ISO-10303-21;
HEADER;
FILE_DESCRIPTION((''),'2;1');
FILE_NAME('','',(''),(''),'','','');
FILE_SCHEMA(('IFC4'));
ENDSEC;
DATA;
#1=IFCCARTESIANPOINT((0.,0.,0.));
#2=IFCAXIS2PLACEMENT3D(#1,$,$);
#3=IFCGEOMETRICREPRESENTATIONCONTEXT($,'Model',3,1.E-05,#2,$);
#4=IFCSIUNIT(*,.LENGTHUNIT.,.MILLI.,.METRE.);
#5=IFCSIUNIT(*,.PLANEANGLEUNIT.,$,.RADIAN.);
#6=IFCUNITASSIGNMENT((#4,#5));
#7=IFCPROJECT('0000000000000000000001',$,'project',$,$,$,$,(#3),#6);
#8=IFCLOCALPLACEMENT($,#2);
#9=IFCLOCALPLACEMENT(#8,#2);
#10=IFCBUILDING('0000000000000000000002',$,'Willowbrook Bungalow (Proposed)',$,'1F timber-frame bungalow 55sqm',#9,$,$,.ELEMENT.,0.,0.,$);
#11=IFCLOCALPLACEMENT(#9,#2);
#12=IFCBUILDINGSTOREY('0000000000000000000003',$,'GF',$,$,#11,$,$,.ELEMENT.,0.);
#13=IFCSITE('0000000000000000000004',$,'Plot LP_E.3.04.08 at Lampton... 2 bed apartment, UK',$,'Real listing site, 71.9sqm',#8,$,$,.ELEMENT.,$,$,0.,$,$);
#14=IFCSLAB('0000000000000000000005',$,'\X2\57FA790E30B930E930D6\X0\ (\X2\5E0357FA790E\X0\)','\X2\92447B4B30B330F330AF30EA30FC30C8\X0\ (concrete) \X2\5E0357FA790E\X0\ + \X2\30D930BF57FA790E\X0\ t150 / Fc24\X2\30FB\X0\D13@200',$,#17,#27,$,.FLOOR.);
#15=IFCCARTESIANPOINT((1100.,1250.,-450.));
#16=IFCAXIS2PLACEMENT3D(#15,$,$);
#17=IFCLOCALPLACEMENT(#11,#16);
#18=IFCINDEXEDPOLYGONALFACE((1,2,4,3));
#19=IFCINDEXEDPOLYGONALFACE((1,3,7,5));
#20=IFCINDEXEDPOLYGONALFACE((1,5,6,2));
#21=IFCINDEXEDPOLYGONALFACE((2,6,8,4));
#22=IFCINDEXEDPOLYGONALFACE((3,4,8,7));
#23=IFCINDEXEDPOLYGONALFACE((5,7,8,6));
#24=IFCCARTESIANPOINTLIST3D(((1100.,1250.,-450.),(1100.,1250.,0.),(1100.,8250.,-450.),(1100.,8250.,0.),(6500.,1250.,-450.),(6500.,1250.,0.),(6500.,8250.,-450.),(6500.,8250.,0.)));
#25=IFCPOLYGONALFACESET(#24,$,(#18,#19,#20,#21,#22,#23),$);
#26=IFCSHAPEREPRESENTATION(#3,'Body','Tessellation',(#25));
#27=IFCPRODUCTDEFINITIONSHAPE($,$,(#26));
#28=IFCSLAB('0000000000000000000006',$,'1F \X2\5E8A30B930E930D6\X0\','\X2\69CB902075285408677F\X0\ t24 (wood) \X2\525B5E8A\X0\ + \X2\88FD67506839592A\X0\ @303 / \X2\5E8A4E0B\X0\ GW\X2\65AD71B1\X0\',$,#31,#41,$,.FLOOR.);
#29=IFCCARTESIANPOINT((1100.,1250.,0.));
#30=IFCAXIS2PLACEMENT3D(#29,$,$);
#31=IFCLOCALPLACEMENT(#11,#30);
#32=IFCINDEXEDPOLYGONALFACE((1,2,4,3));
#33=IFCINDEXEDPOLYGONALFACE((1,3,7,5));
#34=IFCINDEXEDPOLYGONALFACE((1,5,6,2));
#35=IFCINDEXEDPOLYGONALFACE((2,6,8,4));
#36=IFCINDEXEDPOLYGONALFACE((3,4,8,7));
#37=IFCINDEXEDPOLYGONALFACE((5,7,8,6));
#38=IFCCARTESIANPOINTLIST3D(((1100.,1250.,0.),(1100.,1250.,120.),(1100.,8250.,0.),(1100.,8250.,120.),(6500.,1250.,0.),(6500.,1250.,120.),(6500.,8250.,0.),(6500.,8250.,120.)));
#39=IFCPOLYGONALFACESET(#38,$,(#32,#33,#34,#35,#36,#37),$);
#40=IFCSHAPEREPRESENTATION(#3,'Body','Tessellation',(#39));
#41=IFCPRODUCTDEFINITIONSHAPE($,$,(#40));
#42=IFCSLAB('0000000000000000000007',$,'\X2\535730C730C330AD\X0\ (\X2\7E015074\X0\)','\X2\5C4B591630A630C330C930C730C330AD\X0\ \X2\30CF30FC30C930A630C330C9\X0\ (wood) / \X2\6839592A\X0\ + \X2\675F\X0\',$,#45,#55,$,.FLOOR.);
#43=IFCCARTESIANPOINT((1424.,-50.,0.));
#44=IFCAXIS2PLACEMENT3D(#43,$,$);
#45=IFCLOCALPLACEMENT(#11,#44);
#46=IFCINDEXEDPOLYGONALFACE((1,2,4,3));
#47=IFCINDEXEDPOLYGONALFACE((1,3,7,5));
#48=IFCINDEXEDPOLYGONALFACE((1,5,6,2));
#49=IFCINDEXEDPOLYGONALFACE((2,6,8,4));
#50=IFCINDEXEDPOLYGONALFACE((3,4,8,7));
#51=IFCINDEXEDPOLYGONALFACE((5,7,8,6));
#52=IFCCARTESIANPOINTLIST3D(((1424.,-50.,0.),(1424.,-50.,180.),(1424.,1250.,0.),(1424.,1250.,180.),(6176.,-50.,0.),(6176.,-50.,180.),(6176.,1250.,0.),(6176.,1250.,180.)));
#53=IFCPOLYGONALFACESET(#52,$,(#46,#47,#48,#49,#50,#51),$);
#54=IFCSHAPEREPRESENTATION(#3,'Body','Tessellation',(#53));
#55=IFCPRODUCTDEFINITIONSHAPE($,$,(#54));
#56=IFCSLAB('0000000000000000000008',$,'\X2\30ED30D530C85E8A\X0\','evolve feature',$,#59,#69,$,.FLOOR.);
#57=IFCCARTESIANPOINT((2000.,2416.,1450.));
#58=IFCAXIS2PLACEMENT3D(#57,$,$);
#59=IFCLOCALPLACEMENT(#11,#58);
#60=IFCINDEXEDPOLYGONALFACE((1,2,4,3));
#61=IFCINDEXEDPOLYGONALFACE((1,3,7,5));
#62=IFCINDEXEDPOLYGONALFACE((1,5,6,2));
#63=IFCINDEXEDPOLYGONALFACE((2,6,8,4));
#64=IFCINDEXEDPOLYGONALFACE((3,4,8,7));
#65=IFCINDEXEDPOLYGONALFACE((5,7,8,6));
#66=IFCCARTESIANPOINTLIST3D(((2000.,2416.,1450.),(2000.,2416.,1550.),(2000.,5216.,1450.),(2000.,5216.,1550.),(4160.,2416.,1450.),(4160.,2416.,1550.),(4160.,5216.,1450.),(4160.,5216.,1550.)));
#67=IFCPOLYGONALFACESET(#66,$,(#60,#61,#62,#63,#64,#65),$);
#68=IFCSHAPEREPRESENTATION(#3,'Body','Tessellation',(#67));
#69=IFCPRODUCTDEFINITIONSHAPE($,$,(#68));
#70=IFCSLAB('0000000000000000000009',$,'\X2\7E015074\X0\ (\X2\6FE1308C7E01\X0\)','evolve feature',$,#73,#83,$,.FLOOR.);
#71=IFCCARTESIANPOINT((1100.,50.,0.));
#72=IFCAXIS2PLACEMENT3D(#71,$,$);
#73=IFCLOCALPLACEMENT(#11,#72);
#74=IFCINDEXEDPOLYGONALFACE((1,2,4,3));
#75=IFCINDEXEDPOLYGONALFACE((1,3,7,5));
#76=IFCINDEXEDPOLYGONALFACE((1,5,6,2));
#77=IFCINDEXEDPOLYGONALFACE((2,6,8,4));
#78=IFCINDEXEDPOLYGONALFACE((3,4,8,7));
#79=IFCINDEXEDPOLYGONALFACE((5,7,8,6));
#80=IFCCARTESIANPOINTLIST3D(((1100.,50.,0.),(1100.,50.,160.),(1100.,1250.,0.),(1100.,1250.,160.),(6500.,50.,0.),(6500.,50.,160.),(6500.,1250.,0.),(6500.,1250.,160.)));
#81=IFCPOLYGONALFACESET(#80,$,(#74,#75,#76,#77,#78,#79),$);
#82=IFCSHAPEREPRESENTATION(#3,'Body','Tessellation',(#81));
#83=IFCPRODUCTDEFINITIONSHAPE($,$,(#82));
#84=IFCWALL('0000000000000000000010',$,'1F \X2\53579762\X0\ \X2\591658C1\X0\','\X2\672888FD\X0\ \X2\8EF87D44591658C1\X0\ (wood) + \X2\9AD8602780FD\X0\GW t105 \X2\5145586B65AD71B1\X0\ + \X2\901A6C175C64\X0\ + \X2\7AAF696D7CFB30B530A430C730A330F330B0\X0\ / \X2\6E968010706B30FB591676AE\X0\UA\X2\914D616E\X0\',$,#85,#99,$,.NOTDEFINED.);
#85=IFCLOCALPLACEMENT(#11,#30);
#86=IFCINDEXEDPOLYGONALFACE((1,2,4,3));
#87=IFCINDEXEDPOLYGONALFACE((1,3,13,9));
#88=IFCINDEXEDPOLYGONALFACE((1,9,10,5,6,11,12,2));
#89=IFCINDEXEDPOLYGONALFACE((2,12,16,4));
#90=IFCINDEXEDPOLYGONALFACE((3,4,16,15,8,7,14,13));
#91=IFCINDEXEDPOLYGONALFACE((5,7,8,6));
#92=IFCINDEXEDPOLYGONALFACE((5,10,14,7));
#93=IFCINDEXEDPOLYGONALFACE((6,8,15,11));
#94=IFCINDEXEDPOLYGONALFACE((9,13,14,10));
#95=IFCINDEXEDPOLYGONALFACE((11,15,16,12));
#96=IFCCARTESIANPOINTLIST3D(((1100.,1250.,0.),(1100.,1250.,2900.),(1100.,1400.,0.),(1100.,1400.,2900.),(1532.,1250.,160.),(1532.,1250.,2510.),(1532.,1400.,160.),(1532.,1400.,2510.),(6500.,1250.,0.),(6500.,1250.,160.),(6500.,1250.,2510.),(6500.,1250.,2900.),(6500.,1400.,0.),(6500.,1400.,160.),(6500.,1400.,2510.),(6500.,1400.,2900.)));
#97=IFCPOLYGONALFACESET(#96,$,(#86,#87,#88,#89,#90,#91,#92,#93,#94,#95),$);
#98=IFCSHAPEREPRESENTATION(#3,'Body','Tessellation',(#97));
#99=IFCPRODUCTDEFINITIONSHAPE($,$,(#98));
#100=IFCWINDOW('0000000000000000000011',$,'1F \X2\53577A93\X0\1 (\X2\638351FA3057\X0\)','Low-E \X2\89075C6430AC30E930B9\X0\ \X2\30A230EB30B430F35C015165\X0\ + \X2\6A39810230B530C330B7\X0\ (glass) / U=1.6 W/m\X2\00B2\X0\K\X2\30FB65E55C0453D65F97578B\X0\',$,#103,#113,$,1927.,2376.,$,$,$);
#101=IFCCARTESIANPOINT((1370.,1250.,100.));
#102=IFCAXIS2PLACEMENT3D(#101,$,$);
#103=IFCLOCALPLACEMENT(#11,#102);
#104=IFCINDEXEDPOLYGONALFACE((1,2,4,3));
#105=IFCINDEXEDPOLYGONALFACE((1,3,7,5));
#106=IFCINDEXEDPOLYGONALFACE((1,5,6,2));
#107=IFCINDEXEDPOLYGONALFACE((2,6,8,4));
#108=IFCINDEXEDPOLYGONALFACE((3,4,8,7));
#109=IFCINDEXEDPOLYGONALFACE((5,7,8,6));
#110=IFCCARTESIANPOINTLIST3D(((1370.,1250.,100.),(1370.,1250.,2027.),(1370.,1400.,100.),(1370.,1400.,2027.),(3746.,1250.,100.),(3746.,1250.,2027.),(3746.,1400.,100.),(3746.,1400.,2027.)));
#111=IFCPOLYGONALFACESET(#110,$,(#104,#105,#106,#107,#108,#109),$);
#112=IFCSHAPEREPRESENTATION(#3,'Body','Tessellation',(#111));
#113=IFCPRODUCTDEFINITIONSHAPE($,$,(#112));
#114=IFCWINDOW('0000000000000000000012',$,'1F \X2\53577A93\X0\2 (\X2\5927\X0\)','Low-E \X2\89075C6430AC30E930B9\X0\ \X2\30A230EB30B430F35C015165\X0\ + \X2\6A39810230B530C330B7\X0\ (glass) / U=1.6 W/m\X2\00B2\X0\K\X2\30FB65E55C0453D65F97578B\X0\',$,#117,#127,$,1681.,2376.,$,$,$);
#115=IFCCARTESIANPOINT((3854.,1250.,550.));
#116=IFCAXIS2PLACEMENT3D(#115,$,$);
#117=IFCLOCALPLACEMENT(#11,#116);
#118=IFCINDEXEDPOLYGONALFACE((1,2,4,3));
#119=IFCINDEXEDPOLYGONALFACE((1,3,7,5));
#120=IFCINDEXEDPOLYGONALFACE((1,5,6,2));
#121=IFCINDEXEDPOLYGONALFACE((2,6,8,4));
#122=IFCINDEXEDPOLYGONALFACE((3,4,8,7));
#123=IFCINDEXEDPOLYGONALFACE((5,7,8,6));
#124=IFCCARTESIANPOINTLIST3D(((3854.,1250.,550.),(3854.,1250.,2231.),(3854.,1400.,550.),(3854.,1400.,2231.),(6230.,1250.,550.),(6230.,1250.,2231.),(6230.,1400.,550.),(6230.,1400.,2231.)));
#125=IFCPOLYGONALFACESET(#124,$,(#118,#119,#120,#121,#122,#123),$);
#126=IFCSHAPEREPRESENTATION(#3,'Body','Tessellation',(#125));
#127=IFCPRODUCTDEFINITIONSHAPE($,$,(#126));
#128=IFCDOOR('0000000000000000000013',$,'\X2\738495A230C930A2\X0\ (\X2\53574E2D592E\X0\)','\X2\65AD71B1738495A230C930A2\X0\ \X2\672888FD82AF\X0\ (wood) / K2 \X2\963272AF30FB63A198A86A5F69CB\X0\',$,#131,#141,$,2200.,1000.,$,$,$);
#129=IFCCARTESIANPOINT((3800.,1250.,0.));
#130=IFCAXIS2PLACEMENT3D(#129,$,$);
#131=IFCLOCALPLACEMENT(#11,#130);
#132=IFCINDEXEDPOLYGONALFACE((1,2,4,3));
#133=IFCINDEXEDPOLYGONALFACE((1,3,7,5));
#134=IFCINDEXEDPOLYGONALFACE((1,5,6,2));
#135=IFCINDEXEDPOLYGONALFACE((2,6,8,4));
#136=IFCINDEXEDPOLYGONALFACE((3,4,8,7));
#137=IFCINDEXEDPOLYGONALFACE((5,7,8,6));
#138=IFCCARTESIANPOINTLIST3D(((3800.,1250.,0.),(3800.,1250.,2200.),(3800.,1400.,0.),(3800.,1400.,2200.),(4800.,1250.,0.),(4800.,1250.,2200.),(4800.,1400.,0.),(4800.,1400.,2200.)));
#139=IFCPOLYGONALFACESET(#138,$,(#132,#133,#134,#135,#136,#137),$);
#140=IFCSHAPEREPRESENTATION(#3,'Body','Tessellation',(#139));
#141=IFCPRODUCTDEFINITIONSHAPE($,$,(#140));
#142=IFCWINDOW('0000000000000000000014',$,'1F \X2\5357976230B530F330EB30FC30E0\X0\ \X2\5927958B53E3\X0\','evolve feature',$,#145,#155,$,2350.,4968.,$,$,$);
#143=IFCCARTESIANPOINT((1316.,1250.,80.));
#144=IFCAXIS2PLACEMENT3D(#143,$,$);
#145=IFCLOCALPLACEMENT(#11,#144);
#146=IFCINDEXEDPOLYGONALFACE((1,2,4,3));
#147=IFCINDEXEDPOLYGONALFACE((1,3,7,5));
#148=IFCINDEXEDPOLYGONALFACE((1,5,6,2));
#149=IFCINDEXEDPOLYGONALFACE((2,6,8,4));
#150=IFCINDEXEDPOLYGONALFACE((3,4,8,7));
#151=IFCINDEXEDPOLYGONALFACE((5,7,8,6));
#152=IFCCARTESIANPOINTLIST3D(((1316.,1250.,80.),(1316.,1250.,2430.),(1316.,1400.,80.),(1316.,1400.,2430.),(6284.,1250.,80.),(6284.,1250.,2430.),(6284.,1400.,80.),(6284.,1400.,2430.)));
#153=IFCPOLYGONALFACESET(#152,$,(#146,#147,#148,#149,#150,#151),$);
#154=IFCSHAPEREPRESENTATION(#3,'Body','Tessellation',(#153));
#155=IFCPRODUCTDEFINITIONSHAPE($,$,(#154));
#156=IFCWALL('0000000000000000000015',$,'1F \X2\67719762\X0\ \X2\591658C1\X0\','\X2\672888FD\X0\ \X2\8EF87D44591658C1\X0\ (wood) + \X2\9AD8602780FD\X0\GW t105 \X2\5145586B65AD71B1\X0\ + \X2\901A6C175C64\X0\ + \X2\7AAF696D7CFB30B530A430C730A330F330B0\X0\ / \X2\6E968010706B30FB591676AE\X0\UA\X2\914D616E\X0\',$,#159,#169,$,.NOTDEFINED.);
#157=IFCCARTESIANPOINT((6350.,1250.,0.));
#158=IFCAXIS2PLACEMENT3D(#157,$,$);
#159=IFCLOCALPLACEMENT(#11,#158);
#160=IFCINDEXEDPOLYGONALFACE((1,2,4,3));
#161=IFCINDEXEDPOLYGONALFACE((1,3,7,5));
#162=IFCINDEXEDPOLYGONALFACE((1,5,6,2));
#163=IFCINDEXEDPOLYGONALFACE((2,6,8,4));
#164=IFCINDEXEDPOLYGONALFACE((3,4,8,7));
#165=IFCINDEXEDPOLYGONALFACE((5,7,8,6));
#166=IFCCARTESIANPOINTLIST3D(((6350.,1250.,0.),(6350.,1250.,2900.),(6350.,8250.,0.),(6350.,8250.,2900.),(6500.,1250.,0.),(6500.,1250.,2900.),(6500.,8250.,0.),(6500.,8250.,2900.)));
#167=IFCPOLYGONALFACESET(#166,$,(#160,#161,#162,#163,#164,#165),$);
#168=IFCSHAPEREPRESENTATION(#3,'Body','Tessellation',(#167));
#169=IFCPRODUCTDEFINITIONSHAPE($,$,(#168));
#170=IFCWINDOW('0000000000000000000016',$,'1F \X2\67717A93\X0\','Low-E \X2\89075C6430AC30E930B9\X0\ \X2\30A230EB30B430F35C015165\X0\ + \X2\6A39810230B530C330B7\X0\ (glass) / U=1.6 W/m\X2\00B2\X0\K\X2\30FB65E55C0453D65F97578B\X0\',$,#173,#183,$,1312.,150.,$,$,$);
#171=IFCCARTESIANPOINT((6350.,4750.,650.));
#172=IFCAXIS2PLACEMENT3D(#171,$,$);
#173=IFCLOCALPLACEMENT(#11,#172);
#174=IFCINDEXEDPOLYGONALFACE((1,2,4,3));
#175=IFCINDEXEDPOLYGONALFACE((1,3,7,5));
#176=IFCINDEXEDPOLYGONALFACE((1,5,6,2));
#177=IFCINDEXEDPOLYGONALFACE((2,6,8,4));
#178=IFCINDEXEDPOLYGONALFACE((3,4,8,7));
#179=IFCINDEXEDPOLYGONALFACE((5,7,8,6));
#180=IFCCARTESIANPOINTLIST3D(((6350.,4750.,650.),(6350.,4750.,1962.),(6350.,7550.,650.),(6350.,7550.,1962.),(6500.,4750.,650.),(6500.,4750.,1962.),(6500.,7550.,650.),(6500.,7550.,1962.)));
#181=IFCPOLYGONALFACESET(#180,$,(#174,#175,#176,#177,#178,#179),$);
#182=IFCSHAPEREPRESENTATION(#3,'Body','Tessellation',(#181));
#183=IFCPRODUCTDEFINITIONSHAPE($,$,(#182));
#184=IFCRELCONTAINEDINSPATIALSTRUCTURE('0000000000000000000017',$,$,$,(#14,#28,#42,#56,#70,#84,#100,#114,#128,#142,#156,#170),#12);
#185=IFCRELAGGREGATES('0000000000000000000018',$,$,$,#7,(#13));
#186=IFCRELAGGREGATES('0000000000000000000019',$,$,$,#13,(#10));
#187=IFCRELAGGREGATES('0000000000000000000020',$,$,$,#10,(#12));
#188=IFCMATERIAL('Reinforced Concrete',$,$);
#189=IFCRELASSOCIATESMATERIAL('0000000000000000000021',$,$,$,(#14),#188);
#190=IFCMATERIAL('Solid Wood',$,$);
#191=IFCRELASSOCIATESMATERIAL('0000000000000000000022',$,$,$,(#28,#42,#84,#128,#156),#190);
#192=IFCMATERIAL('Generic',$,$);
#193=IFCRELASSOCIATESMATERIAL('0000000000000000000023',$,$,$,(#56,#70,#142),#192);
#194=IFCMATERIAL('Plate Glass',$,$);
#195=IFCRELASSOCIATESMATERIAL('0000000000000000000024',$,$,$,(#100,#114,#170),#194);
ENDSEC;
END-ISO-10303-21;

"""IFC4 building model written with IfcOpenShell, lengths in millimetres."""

from ifc_helpers import new_model, si_unit, frame, frame_2d, origin, place, context, project, spatial, rectangle, extrude, material, element, fill, save


model = new_model("IFC4")

# Units and contexts
model_context = context("Model", 3, precision=1e-05, world=origin())
ifc_project = project(units=[si_unit("LENGTHUNIT", "METRE", prefix="MILLI"), si_unit("PLANEANGLEUNIT", "RADIAN")], contexts=[model_context])

# Site, building, storey
site_placement = place(None, origin())
site = spatial("IfcSite", under=ifc_project, at=site_placement, Name="Plot LP_E.3.04.08 at Lampton... 2 bed apartment, UK", ObjectType="Real listing site, 71.9sqm", CompositionType="ELEMENT", RefElevation=0.0)
building_placement = place(site_placement, origin())
building = spatial("IfcBuilding", under=site, at=building_placement, Name="Willowbrook Bungalow (Proposed)", ObjectType="1F timber-frame bungalow 55sqm", CompositionType="ELEMENT", ElevationOfRefHeight=0.0, ElevationOfTerrain=0.0)
storey_placement = place(building_placement, origin())
storey = spatial("IfcBuildingStorey", under=building, at=storey_placement, Name="GF", CompositionType="ELEMENT", Elevation=0.0)

# Slabs
ifc_material_1 = material(Name="Reinforced Concrete")
slab_1_placement = place(storey_placement, frame((1100.0, 1250.0, -450.0)))
element("IfcSlab", 1, at=slab_1_placement, inside=storey, material=ifc_material_1, Name="基礎スラブ (布基礎)", Description="鉄筋コンクリート (concrete) 布基礎 + ベタ基礎 t150 / Fc24・D13@200", PredefinedType="FLOOR", context=model_context, shape_type="SweptSolid", body=[
    extrude(rectangle(XDim=5400.0, YDim=7000.0, at=frame_2d((2700.0, 3500.0))), frame((1100.0, 1250.0, -450.0)), (0.0, 0.0, 1.0), 450.0),
])
ifc_material_2 = material(Name="Solid Wood")
slab_2_placement = place(storey_placement, frame((1100.0, 1250.0, 0.0)))
element("IfcSlab", 2, at=slab_2_placement, inside=storey, material=ifc_material_2, Name="1F 床スラブ", Description="構造用合板 t24 (wood) 剛床 + 製材根太 @303 / 床下 GW断熱", PredefinedType="FLOOR", context=model_context, shape_type="SweptSolid", body=[
    extrude(rectangle(XDim=5400.0, YDim=7000.0, at=frame_2d((2700.0, 3500.0))), frame((1100.0, 1250.0, 0.0)), (0.0, 0.0, 1.0), 120.0),
])
slab_3_placement = place(storey_placement, frame((1424.0, -50.0, 0.0)))
element("IfcSlab", 3, at=slab_3_placement, inside=storey, material=ifc_material_2, Name="南デッキ (縁側)", Description="屋外ウッドデッキ ハードウッド (wood) / 根太 + 束", PredefinedType="FLOOR", context=model_context, shape_type="SweptSolid", body=[
    extrude(rectangle(XDim=4752.0, YDim=1300.0, at=frame_2d((2376.0, 650.0))), frame((1424.0, -50.0, 0.0)), (0.0, 0.0, 1.0), 180.0),
])
ifc_material_3 = material(Name="Generic")
slab_4_placement = place(storey_placement, frame((2000.0, 2416.0, 1450.0)))
element("IfcSlab", 4, at=slab_4_placement, inside=storey, material=ifc_material_3, Name="ロフト床", Description="evolve feature", PredefinedType="FLOOR", context=model_context, shape_type="SweptSolid", body=[
    extrude(rectangle(XDim=2160.0, YDim=2800.0, at=frame_2d((1080.0, 1400.0))), frame((2000.0, 2416.0, 1450.0)), (0.0, 0.0, 1.0), 100.0),
])
slab_5_placement = place(storey_placement, frame((1100.0, 50.0, 0.0)))
element("IfcSlab", 5, at=slab_5_placement, inside=storey, material=ifc_material_3, Name="縁側 (濡れ縁)", Description="evolve feature", PredefinedType="FLOOR", context=model_context, shape_type="SweptSolid", body=[
    extrude(rectangle(XDim=5400.0, YDim=1200.0, at=frame_2d((2700.0, 600.0))), frame((1100.0, 50.0, 0.0)), (0.0, 0.0, 1.0), 160.0),
])

# Wall, openings, windows, door
wall_1_placement = place(storey_placement, frame((1100.0, 1250.0, 0.0)))
wall_1 = element("IfcWall", 6, at=wall_1_placement, inside=storey, material=ifc_material_2, Name="1F 南面 外壁", Description="木製 軸組外壁 (wood) + 高性能GW t105 充填断熱 + 通気層 + 窯業系サイディング / 準耐火・外皮UA配慮", PredefinedType="NOTDEFINED", context=model_context, shape_type="SweptSolid", body=[
    extrude(rectangle(XDim=5400.0, YDim=150.0, at=frame_2d((2700.0, 75.0))), frame((1100.0, 1250.0, 0.0)), (0.0, 0.0, 1.0), 2900.0),
])
opening_1_placement = place(storey_placement, frame((1370.0, 1250.0, 100.0)))
opening_1 = element("IfcOpeningElement", 7, at=opening_1_placement, cuts=wall_1, PredefinedType="NOTDEFINED", context=model_context, shape_type="SweptSolid", body=[
    extrude(rectangle(XDim=2376.0, YDim=150.0, at=frame_2d((1188.0, 75.0))), frame((1370.0, 1250.0, 100.0)), (0.0, 0.0, 1.0), 1927.0),
])
opening_2_placement = place(storey_placement, frame((3854.0, 1250.0, 550.0)))
opening_2 = element("IfcOpeningElement", 8, at=opening_2_placement, cuts=wall_1, PredefinedType="NOTDEFINED", context=model_context, shape_type="SweptSolid", body=[
    extrude(rectangle(XDim=2376.0, YDim=150.0, at=frame_2d((1188.0, 75.0))), frame((3854.0, 1250.0, 550.0)), (0.0, 0.0, 1.0), 1681.0),
])
opening_3_placement = place(storey_placement, frame((3800.0, 1250.0, 0.0)))
opening_3 = element("IfcOpeningElement", 9, at=opening_3_placement, cuts=wall_1, PredefinedType="NOTDEFINED", context=model_context, shape_type="SweptSolid", body=[
    extrude(rectangle(XDim=1000.0, YDim=150.0, at=frame_2d((500.0, 75.0))), frame((3800.0, 1250.0, 0.0)), (0.0, 0.0, 1.0), 2200.0),
])
opening_4_placement = place(storey_placement, frame((1316.0, 1250.0, 80.0)))
opening_4 = element("IfcOpeningElement", 10, at=opening_4_placement, cuts=wall_1, PredefinedType="NOTDEFINED", context=model_context, shape_type="SweptSolid", body=[
    extrude(rectangle(XDim=4968.0, YDim=150.0, at=frame_2d((2484.0, 75.0))), frame((1316.0, 1250.0, 80.0)), (0.0, 0.0, 1.0), 2350.0),
])
ifc_material_4 = material(Name="Plate Glass")
window_1_placement = place(storey_placement, frame((1370.0, 1250.0, 100.0)))
window_1 = element("IfcWindow", 11, at=window_1_placement, inside=storey, material=ifc_material_4, Name="1F 南窓1 (掃出し)", Description="Low-E 複層ガラス アルゴン封入 + 樹脂サッシ (glass) / U=1.6 W/m²K・日射取得型", OverallHeight=1927.0, OverallWidth=2376.0, context=model_context, shape_type="SweptSolid", body=[
    extrude(rectangle(XDim=2376.0, YDim=150.0, at=frame_2d((1188.0, 75.0))), frame((1370.0, 1250.0, 100.0)), (0.0, 0.0, 1.0), 1927.0),
])
fill(opening_1, window_1)
window_2_placement = place(storey_placement, frame((3854.0, 1250.0, 550.0)))
window_2 = element("IfcWindow", 12, at=window_2_placement, inside=storey, material=ifc_material_4, Name="1F 南窓2 (大)", Description="Low-E 複層ガラス アルゴン封入 + 樹脂サッシ (glass) / U=1.6 W/m²K・日射取得型", OverallHeight=1681.0, OverallWidth=2376.0, context=model_context, shape_type="SweptSolid", body=[
    extrude(rectangle(XDim=2376.0, YDim=150.0, at=frame_2d((1188.0, 75.0))), frame((3854.0, 1250.0, 550.0)), (0.0, 0.0, 1.0), 1681.0),
])
fill(opening_2, window_2)
door_placement = place(storey_placement, frame((3800.0, 1250.0, 0.0)))
door = element("IfcDoor", 13, at=door_placement, inside=storey, material=ifc_material_2, Name="玄関ドア (南中央)", Description="断熱玄関ドア 木製芯 (wood) / K2 防犯・採風機構", OverallHeight=2200.0, OverallWidth=1000.0, context=model_context, shape_type="SweptSolid", body=[
    extrude(rectangle(XDim=1000.0, YDim=150.0, at=frame_2d((500.0, 75.0))), frame((3800.0, 1250.0, 0.0)), (0.0, 0.0, 1.0), 2200.0),
])
fill(opening_3, door)
window_3_placement = place(storey_placement, frame((1316.0, 1250.0, 80.0)))
window_3 = element("IfcWindow", 14, at=window_3_placement, inside=storey, material=ifc_material_3, Name="1F 南面サンルーム 大開口", Description="evolve feature", OverallHeight=2350.0, OverallWidth=4968.0, context=model_context, shape_type="SweptSolid", body=[
    extrude(rectangle(XDim=4968.0, YDim=150.0, at=frame_2d((2484.0, 75.0))), frame((1316.0, 1250.0, 80.0)), (0.0, 0.0, 1.0), 2350.0),
])
fill(opening_4, window_3)

# Wall, opening, window
wall_2_placement = place(storey_placement, frame((6350.0, 1250.0, 0.0)))
wall_2 = element("IfcWall", 15, at=wall_2_placement, inside=storey, material=ifc_material_2, Name="1F 東面 外壁", Description="木製 軸組外壁 (wood) + 高性能GW t105 充填断熱 + 通気層 + 窯業系サイディング / 準耐火・外皮UA配慮", PredefinedType="NOTDEFINED", context=model_context, shape_type="SweptSolid", body=[
    extrude(rectangle(XDim=150.0, YDim=7000.0, at=frame_2d((75.0, 3500.0))), frame((6350.0, 1250.0, 0.0)), (0.0, 0.0, 1.0), 2900.0),
])
opening_5_placement = place(storey_placement, frame((6350.0, 4750.0, 650.0)))
opening_5 = element("IfcOpeningElement", 16, at=opening_5_placement, cuts=wall_2, PredefinedType="NOTDEFINED", context=model_context, shape_type="SweptSolid", body=[
    extrude(rectangle(XDim=150.0, YDim=2800.0, at=frame_2d((75.0, 1400.0))), frame((6350.0, 4750.0, 650.0)), (0.0, 0.0, 1.0), 1312.0),
])
window_4_placement = place(storey_placement, frame((6350.0, 4750.0, 650.0)))
window_4 = element("IfcWindow", 17, at=window_4_placement, inside=storey, material=ifc_material_4, Name="1F 東窓", Description="Low-E 複層ガラス アルゴン封入 + 樹脂サッシ (glass) / U=1.6 W/m²K・日射取得型", OverallHeight=1312.0, OverallWidth=150.0, context=model_context, shape_type="SweptSolid", body=[
    extrude(rectangle(XDim=150.0, YDim=2800.0, at=frame_2d((75.0, 1400.0))), frame((6350.0, 4750.0, 650.0)), (0.0, 0.0, 1.0), 1312.0),
])
fill(opening_5, window_4)

save(model, "model.ifc")
